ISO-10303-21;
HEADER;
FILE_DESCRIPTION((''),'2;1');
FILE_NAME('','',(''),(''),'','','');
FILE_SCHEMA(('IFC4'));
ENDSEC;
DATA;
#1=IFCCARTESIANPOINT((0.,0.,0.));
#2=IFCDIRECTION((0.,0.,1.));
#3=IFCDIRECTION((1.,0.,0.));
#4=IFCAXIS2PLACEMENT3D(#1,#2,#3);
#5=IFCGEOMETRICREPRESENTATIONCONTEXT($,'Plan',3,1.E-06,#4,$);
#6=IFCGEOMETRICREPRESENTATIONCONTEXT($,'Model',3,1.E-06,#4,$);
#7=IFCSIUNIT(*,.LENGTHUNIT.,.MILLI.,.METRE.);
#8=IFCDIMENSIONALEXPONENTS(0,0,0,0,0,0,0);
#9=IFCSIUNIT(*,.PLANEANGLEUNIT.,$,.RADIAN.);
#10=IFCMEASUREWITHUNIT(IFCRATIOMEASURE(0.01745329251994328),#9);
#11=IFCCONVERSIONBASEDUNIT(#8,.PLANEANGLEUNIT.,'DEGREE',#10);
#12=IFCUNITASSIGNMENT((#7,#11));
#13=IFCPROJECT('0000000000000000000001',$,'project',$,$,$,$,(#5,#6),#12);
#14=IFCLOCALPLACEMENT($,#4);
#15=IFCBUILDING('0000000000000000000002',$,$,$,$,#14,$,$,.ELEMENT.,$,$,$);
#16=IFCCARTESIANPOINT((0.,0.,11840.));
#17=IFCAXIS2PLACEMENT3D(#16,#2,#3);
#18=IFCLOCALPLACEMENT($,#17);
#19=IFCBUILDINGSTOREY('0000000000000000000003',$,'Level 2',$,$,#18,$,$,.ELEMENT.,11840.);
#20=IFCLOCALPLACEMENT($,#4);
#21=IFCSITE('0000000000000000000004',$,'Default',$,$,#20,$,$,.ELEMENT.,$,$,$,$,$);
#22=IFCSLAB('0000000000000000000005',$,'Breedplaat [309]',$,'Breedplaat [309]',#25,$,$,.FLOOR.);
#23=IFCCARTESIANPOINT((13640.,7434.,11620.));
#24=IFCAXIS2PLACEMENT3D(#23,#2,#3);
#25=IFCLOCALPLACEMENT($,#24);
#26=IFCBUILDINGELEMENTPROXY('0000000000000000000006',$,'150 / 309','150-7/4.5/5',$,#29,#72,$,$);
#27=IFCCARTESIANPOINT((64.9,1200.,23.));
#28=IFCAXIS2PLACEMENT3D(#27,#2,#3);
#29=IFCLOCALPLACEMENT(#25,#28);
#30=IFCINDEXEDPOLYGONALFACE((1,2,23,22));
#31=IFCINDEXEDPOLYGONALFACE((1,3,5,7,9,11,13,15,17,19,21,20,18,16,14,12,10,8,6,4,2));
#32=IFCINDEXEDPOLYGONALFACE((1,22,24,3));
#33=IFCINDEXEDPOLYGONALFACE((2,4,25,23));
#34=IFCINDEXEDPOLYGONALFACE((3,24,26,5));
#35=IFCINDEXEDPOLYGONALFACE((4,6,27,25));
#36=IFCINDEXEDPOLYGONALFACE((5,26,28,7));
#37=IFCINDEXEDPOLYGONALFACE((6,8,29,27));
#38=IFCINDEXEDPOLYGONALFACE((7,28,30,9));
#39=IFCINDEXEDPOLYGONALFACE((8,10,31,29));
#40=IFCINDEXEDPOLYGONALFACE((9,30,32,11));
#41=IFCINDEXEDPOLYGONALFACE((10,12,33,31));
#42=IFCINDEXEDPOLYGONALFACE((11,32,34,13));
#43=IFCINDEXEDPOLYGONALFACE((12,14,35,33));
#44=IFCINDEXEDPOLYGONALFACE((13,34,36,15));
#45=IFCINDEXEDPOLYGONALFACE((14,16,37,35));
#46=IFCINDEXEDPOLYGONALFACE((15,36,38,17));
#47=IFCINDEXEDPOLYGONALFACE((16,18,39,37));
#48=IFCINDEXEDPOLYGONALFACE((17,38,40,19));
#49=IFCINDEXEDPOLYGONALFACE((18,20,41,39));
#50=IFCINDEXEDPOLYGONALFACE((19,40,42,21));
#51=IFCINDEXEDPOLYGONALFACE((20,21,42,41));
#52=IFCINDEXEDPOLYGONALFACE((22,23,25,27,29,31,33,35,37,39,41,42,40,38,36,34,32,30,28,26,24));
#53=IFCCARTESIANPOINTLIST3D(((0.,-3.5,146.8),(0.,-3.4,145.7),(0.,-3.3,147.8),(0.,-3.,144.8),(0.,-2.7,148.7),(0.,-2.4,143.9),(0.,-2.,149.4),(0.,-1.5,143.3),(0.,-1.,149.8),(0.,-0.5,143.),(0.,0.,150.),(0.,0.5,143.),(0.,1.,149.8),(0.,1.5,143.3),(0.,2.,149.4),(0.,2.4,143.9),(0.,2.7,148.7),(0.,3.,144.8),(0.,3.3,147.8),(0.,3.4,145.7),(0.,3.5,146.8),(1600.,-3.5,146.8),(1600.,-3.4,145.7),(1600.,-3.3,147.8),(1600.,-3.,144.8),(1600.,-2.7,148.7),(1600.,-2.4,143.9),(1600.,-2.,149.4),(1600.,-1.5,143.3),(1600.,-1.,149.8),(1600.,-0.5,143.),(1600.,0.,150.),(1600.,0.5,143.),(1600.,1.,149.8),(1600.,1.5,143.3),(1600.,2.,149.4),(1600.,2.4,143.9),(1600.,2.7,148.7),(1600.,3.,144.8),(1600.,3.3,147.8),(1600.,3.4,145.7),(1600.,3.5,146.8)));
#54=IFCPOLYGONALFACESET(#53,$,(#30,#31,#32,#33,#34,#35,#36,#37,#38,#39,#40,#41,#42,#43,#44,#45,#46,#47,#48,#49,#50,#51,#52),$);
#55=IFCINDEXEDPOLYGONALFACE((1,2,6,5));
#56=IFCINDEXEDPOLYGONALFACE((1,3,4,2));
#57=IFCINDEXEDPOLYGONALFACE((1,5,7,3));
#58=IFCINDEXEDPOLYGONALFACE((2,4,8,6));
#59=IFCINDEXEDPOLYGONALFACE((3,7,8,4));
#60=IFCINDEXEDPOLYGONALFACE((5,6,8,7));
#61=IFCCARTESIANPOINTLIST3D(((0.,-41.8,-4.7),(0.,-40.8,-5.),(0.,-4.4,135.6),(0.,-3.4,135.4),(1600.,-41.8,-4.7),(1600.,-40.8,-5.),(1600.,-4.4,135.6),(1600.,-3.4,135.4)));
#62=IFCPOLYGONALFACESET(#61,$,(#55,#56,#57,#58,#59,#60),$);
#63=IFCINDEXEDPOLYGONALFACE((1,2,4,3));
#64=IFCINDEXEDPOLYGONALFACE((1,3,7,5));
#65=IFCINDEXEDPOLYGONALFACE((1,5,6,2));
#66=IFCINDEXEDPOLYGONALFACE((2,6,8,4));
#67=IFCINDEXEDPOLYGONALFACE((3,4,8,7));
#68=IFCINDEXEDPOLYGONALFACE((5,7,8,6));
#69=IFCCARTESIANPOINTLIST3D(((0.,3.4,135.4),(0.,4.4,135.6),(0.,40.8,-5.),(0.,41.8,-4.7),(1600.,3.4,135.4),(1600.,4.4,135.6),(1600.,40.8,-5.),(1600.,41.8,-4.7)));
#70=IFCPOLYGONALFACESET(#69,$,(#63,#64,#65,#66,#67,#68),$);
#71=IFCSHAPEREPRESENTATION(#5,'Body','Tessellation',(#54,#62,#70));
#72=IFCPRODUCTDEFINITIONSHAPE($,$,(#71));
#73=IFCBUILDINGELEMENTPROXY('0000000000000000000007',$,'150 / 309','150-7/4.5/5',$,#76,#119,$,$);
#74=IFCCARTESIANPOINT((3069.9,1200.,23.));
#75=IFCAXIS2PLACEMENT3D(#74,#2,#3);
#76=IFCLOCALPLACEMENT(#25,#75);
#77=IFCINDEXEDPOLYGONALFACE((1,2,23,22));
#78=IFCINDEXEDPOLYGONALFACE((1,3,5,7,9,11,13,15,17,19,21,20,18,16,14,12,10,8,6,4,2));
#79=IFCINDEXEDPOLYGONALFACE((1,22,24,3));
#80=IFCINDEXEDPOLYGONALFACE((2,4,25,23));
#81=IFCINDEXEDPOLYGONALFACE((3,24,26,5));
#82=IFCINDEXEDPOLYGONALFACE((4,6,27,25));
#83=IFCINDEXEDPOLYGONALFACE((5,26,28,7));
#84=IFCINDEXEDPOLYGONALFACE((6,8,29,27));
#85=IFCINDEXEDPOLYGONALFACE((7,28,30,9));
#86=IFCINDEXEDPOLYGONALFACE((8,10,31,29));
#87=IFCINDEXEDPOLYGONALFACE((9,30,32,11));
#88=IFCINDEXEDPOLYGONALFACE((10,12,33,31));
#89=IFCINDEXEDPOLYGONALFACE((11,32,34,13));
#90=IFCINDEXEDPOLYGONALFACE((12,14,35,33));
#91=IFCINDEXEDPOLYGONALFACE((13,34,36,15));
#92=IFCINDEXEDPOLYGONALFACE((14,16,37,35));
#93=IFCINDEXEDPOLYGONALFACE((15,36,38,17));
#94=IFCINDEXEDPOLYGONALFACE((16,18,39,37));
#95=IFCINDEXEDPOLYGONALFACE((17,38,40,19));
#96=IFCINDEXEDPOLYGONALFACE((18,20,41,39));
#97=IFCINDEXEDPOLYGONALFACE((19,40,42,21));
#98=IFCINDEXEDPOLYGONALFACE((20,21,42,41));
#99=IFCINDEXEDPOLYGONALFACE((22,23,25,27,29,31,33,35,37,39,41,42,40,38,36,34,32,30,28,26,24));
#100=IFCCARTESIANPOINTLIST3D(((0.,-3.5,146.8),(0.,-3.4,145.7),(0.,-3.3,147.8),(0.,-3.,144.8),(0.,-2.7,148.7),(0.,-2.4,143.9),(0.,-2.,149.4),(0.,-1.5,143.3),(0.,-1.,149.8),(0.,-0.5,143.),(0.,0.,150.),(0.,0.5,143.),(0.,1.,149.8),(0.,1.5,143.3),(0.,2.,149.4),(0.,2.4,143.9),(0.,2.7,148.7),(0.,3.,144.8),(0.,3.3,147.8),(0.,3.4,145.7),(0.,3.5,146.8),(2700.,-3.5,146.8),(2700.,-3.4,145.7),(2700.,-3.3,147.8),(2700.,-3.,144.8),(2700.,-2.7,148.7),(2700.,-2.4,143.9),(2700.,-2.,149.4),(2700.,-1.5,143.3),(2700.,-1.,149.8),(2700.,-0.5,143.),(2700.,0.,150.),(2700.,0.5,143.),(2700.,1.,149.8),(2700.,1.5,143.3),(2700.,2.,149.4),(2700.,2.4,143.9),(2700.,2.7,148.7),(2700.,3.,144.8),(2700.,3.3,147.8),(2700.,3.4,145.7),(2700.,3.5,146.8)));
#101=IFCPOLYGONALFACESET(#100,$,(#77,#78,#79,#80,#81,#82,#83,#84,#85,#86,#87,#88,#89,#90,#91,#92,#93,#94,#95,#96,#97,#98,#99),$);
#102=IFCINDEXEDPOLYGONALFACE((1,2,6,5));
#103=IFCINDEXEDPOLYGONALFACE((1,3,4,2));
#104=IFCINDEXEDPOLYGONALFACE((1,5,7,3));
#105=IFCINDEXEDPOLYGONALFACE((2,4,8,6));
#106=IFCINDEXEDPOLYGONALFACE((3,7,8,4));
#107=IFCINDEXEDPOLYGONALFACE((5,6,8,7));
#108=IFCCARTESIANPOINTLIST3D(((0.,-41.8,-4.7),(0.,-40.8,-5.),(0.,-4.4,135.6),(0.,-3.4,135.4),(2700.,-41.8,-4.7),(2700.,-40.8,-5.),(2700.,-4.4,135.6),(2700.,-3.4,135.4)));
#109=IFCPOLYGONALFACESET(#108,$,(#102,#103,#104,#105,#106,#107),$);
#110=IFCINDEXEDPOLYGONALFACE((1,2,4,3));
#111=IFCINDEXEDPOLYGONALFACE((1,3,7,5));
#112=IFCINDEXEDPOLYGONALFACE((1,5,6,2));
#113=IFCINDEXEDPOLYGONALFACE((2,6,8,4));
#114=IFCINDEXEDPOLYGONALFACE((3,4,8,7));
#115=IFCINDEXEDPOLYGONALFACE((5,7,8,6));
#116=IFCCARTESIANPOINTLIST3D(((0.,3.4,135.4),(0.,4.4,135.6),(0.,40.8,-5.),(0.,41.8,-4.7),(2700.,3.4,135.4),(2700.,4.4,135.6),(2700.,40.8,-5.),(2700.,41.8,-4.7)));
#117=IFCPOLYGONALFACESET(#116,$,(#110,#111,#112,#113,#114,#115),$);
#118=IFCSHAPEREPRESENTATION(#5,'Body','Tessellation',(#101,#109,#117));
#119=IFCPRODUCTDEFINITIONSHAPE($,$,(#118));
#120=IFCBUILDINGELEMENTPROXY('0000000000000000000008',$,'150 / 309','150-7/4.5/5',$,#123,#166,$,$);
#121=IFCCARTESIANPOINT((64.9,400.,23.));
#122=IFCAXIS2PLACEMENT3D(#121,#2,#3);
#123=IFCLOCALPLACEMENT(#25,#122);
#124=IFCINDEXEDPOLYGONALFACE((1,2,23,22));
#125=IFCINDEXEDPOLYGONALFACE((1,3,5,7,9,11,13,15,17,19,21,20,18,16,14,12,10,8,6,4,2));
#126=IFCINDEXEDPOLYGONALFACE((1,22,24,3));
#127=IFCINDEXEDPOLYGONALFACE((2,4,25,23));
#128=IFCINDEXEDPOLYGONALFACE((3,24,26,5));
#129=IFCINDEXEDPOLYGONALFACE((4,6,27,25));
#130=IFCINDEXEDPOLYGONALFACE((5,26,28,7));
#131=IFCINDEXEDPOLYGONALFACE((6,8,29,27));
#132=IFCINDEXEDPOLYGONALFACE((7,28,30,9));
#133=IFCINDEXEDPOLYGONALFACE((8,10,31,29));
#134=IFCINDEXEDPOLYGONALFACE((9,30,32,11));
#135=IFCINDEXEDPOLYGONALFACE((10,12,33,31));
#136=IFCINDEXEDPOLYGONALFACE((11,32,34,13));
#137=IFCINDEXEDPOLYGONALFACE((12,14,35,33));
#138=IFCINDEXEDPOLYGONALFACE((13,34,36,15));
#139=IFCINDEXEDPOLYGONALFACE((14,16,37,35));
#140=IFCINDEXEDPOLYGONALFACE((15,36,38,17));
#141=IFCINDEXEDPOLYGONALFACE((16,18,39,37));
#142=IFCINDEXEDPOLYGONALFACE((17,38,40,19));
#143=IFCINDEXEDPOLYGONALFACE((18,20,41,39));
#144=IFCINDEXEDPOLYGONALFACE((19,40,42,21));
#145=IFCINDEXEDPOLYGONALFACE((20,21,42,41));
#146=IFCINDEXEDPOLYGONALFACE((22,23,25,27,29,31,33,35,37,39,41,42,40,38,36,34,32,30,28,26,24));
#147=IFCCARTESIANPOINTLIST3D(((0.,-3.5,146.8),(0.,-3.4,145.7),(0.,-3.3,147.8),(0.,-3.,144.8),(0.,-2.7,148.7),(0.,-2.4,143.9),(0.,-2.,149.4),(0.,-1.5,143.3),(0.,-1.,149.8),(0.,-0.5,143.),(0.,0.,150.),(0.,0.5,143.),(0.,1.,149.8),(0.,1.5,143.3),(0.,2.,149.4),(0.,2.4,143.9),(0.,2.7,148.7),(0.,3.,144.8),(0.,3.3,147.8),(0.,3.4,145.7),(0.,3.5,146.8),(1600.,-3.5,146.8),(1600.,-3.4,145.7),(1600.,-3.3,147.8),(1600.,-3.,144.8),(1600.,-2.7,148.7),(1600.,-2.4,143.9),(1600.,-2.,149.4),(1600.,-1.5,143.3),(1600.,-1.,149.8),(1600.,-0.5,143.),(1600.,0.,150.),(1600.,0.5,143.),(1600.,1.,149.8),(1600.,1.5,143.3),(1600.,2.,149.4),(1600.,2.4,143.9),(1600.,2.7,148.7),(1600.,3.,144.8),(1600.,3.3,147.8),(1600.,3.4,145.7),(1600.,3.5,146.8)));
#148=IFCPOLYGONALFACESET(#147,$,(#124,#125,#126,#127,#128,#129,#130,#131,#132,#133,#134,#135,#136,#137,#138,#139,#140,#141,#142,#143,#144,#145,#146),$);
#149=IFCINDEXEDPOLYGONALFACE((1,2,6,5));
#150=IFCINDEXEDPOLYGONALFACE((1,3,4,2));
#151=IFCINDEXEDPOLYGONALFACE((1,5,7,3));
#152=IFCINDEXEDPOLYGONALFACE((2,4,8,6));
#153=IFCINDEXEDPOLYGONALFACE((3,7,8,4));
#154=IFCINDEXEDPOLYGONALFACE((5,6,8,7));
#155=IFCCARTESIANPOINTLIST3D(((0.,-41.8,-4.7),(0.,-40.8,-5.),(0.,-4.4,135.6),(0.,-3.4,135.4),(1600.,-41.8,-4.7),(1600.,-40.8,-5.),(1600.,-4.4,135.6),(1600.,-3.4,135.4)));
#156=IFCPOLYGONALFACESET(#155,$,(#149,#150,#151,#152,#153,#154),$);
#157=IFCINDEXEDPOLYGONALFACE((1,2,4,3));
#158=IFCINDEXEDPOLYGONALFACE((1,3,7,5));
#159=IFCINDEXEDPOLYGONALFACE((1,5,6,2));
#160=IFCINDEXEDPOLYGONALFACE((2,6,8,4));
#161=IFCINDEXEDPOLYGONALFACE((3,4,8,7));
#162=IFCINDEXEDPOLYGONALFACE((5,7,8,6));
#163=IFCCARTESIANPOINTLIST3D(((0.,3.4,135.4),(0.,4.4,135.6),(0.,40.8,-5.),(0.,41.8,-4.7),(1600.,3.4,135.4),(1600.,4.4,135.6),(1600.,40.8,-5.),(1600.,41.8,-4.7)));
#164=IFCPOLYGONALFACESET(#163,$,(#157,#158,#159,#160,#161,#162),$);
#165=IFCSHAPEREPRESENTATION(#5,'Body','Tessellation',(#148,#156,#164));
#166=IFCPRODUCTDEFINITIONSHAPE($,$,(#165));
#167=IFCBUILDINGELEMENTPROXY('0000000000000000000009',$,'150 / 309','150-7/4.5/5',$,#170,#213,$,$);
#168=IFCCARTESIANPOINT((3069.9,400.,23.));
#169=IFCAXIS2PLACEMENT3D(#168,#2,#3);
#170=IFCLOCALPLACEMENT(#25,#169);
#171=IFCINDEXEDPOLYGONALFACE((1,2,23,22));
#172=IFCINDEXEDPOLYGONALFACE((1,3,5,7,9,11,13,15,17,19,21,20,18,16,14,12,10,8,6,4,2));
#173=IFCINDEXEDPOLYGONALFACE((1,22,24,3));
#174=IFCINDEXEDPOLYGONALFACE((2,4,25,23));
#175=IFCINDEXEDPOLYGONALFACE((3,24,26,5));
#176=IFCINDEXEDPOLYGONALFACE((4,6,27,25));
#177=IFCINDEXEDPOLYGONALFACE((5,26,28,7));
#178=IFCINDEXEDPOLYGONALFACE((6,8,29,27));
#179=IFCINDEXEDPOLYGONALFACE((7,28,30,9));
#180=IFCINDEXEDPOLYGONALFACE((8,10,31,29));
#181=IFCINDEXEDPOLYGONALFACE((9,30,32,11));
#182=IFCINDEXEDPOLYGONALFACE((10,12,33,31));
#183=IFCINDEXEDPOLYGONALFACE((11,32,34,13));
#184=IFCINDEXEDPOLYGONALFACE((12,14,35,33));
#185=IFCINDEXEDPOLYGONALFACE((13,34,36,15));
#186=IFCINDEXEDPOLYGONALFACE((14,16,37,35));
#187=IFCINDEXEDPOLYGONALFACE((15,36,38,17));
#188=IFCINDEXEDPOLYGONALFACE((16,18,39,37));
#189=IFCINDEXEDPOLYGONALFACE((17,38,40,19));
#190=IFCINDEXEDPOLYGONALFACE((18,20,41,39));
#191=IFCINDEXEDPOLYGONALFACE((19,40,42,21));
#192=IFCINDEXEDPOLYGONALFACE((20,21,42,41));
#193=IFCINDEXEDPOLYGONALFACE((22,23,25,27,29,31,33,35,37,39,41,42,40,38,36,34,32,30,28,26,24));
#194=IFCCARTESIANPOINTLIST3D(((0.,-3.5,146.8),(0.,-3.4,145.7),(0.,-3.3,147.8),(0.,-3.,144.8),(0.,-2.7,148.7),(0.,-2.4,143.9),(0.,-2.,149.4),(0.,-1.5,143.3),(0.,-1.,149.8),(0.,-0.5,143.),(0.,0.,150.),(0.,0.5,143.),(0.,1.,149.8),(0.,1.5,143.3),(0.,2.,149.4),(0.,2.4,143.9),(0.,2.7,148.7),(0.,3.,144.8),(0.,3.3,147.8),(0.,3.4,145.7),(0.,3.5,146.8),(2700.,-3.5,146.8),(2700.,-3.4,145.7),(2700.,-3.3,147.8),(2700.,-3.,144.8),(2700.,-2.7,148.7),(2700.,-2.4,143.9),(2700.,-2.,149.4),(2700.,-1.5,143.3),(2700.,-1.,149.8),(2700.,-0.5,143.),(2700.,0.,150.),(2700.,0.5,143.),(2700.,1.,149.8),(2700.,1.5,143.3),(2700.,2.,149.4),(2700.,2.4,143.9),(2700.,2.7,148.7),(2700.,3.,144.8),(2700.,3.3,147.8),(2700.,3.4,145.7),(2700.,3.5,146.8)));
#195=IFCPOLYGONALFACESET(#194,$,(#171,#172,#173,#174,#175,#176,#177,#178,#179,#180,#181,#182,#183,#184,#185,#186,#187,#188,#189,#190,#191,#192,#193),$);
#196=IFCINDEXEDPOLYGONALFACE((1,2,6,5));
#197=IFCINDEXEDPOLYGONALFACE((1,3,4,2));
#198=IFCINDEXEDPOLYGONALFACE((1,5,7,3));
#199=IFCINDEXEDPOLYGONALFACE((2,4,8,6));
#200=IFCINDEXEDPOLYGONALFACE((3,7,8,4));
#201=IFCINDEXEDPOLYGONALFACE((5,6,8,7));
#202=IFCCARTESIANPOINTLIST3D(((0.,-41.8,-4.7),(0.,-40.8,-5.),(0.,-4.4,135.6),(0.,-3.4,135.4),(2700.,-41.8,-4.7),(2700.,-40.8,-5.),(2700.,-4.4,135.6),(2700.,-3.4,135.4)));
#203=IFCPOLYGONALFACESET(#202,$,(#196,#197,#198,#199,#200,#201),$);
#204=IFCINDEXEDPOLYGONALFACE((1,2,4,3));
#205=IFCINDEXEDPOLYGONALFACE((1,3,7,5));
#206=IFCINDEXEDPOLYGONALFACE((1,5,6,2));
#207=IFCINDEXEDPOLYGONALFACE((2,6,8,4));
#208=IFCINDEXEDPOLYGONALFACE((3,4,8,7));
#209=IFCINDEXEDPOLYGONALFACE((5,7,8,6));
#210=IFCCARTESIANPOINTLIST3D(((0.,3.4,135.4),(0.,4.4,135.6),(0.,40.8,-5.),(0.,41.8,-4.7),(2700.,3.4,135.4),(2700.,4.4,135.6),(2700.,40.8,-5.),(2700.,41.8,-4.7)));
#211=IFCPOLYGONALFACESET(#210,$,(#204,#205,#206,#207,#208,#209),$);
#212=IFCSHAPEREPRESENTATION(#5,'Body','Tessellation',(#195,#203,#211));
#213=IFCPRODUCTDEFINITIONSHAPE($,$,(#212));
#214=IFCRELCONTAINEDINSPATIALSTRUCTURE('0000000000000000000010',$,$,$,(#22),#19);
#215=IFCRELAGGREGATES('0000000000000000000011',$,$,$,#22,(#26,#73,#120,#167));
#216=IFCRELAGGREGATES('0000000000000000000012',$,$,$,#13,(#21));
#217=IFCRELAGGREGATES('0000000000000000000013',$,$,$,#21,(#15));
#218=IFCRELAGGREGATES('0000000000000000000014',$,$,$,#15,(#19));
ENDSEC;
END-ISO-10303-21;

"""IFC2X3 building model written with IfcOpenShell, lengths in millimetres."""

from ifc_helpers import new_model, entity, si_unit, converted_unit, frame, origin_with_axes, origin_2d_with_axis, place, context, project, spatial, rectangle, circle, extrude, element, aggregate, save


model = new_model("IFC2X3")

# Units and contexts
plan_context = context("Plan", 3, precision=1e-06, world=origin_with_axes())
model_context = context("Model", 3, precision=1e-06, world=origin_with_axes())
ifc_project = project(units=[si_unit("LENGTHUNIT", "METRE", prefix="MILLI"), converted_unit("PLANEANGLEUNIT", "DEGREE", entity("IfcRatioMeasure", 0.01745329251994328), si_unit("PLANEANGLEUNIT", "RADIAN"), dimensions=[0, 0, 0, 0, 0, 0, 0])], contexts=[plan_context, model_context])

# Site, building, storey
site_placement = place(None, origin_with_axes())
site = spatial("IfcSite", under=ifc_project, at=site_placement, Name="Default", CompositionType="ELEMENT")
building_placement = place(None, origin_with_axes())
building = spatial("IfcBuilding", under=site, at=building_placement, CompositionType="ELEMENT")
storey_placement = place(None, frame((0.0, 0.0, 11840.0), z_axis=(0.0, 0.0, 1.0), x_axis=(1.0, 0.0, 0.0)))
storey = spatial("IfcBuildingStorey", under=building, at=storey_placement, Name="Level 2", CompositionType="ELEMENT", Elevation=11840.0)

# Slab, building element proxies
slab_1_placement = place(None, frame((13640.0, 7434.0, 11620.0), z_axis=(0.0, 0.0, 1.0), x_axis=(1.0, 0.0, 0.0)))
slab_1 = element("IfcSlab", 1, at=slab_1_placement, inside=storey, Name="Breedplaat [309]", ObjectType="Breedplaat [309]", PredefinedType="FLOOR")
proxy_1_placement = place(slab_1_placement, frame((64.9, 1200.0, 23.0), z_axis=(0.0, 0.0, 1.0), x_axis=(1.0, 0.0, 0.0)))
proxy_1 = element("IfcBuildingElementProxy", 2, at=proxy_1_placement, Name="150 / 309", Description="150-7/4.5/5", context=plan_context, shape_type="SweptSolid", body=[
    extrude(circle(Radius=3.5, at=origin_2d_with_axis()), frame((0.0, 0.0, 146.5), z_axis=(1.0, 0.0, 0.0), x_axis=(0.0, 0.0, 1.0)), (0.0, 0.0, 1.0), 1600.0),
    extrude(rectangle(XDim=145.2, YDim=1.0, at=origin_2d_with_axis()), frame((0.0, -22.6, 65.3), z_axis=(1.0, 0.0, 0.0), x_axis=(0.0, 0.257663, 0.966235)), (0.0, 0.0, 1.0), 1600.0),
    extrude(rectangle(XDim=145.2, YDim=1.0, at=origin_2d_with_axis()), frame((0.0, 22.6, 65.3), z_axis=(1.0, 0.0, 0.0), x_axis=(0.0, -0.257663, 0.966235)), (0.0, 0.0, 1.0), 1600.0),
])
proxy_2_placement = place(slab_1_placement, frame((3069.9, 1200.0, 23.0), z_axis=(0.0, 0.0, 1.0), x_axis=(1.0, 0.0, 0.0)))
proxy_2 = element("IfcBuildingElementProxy", 3, at=proxy_2_placement, Name="150 / 309", Description="150-7/4.5/5", context=plan_context, shape_type="SweptSolid", body=[
    extrude(circle(Radius=3.5, at=origin_2d_with_axis()), frame((0.0, 0.0, 146.5), z_axis=(1.0, 0.0, 0.0), x_axis=(0.0, 0.0, 1.0)), (0.0, 0.0, 1.0), 2700.0),
    extrude(rectangle(XDim=145.2, YDim=1.0, at=origin_2d_with_axis()), frame((0.0, -22.6, 65.3), z_axis=(1.0, 0.0, 0.0), x_axis=(0.0, 0.257663, 0.966235)), (0.0, 0.0, 1.0), 2700.0),
    extrude(rectangle(XDim=145.2, YDim=1.0, at=origin_2d_with_axis()), frame((0.0, 22.6, 65.3), z_axis=(1.0, 0.0, 0.0), x_axis=(0.0, -0.257663, 0.966235)), (0.0, 0.0, 1.0), 2700.0),
])
proxy_3_placement = place(slab_1_placement, frame((64.9, 400.0, 23.0), z_axis=(0.0, 0.0, 1.0), x_axis=(1.0, 0.0, 0.0)))
proxy_3 = element("IfcBuildingElementProxy", 4, at=proxy_3_placement, Name="150 / 309", Description="150-7/4.5/5", context=plan_context, shape_type="SweptSolid", body=[
    extrude(circle(Radius=3.5, at=origin_2d_with_axis()), frame((0.0, 0.0, 146.5), z_axis=(1.0, 0.0, 0.0), x_axis=(0.0, 0.0, 1.0)), (0.0, 0.0, 1.0), 1600.0),
    extrude(rectangle(XDim=145.2, YDim=1.0, at=origin_2d_with_axis()), frame((0.0, -22.6, 65.3), z_axis=(1.0, 0.0, 0.0), x_axis=(0.0, 0.257663, 0.966235)), (0.0, 0.0, 1.0), 1600.0),
    extrude(rectangle(XDim=145.2, YDim=1.0, at=origin_2d_with_axis()), frame((0.0, 22.6, 65.3), z_axis=(1.0, 0.0, 0.0), x_axis=(0.0, -0.257663, 0.966235)), (0.0, 0.0, 1.0), 1600.0),
])
proxy_4_placement = place(slab_1_placement, frame((3069.9, 400.0, 23.0), z_axis=(0.0, 0.0, 1.0), x_axis=(1.0, 0.0, 0.0)))
proxy_4 = element("IfcBuildingElementProxy", 5, at=proxy_4_placement, Name="150 / 309", Description="150-7/4.5/5", context=plan_context, shape_type="SweptSolid", body=[
    extrude(circle(Radius=3.5, at=origin_2d_with_axis()), frame((0.0, 0.0, 146.5), z_axis=(1.0, 0.0, 0.0), x_axis=(0.0, 0.0, 1.0)), (0.0, 0.0, 1.0), 2700.0),
    extrude(rectangle(XDim=145.2, YDim=1.0, at=origin_2d_with_axis()), frame((0.0, -22.6, 65.3), z_axis=(1.0, 0.0, 0.0), x_axis=(0.0, 0.257663, 0.966235)), (0.0, 0.0, 1.0), 2700.0),
    extrude(rectangle(XDim=145.2, YDim=1.0, at=origin_2d_with_axis()), frame((0.0, 22.6, 65.3), z_axis=(1.0, 0.0, 0.0), x_axis=(0.0, -0.257663, 0.966235)), (0.0, 0.0, 1.0), 2700.0),
])
aggregate(slab_1, [proxy_1, proxy_2, proxy_3, proxy_4])

save(model, "model.ifc")
